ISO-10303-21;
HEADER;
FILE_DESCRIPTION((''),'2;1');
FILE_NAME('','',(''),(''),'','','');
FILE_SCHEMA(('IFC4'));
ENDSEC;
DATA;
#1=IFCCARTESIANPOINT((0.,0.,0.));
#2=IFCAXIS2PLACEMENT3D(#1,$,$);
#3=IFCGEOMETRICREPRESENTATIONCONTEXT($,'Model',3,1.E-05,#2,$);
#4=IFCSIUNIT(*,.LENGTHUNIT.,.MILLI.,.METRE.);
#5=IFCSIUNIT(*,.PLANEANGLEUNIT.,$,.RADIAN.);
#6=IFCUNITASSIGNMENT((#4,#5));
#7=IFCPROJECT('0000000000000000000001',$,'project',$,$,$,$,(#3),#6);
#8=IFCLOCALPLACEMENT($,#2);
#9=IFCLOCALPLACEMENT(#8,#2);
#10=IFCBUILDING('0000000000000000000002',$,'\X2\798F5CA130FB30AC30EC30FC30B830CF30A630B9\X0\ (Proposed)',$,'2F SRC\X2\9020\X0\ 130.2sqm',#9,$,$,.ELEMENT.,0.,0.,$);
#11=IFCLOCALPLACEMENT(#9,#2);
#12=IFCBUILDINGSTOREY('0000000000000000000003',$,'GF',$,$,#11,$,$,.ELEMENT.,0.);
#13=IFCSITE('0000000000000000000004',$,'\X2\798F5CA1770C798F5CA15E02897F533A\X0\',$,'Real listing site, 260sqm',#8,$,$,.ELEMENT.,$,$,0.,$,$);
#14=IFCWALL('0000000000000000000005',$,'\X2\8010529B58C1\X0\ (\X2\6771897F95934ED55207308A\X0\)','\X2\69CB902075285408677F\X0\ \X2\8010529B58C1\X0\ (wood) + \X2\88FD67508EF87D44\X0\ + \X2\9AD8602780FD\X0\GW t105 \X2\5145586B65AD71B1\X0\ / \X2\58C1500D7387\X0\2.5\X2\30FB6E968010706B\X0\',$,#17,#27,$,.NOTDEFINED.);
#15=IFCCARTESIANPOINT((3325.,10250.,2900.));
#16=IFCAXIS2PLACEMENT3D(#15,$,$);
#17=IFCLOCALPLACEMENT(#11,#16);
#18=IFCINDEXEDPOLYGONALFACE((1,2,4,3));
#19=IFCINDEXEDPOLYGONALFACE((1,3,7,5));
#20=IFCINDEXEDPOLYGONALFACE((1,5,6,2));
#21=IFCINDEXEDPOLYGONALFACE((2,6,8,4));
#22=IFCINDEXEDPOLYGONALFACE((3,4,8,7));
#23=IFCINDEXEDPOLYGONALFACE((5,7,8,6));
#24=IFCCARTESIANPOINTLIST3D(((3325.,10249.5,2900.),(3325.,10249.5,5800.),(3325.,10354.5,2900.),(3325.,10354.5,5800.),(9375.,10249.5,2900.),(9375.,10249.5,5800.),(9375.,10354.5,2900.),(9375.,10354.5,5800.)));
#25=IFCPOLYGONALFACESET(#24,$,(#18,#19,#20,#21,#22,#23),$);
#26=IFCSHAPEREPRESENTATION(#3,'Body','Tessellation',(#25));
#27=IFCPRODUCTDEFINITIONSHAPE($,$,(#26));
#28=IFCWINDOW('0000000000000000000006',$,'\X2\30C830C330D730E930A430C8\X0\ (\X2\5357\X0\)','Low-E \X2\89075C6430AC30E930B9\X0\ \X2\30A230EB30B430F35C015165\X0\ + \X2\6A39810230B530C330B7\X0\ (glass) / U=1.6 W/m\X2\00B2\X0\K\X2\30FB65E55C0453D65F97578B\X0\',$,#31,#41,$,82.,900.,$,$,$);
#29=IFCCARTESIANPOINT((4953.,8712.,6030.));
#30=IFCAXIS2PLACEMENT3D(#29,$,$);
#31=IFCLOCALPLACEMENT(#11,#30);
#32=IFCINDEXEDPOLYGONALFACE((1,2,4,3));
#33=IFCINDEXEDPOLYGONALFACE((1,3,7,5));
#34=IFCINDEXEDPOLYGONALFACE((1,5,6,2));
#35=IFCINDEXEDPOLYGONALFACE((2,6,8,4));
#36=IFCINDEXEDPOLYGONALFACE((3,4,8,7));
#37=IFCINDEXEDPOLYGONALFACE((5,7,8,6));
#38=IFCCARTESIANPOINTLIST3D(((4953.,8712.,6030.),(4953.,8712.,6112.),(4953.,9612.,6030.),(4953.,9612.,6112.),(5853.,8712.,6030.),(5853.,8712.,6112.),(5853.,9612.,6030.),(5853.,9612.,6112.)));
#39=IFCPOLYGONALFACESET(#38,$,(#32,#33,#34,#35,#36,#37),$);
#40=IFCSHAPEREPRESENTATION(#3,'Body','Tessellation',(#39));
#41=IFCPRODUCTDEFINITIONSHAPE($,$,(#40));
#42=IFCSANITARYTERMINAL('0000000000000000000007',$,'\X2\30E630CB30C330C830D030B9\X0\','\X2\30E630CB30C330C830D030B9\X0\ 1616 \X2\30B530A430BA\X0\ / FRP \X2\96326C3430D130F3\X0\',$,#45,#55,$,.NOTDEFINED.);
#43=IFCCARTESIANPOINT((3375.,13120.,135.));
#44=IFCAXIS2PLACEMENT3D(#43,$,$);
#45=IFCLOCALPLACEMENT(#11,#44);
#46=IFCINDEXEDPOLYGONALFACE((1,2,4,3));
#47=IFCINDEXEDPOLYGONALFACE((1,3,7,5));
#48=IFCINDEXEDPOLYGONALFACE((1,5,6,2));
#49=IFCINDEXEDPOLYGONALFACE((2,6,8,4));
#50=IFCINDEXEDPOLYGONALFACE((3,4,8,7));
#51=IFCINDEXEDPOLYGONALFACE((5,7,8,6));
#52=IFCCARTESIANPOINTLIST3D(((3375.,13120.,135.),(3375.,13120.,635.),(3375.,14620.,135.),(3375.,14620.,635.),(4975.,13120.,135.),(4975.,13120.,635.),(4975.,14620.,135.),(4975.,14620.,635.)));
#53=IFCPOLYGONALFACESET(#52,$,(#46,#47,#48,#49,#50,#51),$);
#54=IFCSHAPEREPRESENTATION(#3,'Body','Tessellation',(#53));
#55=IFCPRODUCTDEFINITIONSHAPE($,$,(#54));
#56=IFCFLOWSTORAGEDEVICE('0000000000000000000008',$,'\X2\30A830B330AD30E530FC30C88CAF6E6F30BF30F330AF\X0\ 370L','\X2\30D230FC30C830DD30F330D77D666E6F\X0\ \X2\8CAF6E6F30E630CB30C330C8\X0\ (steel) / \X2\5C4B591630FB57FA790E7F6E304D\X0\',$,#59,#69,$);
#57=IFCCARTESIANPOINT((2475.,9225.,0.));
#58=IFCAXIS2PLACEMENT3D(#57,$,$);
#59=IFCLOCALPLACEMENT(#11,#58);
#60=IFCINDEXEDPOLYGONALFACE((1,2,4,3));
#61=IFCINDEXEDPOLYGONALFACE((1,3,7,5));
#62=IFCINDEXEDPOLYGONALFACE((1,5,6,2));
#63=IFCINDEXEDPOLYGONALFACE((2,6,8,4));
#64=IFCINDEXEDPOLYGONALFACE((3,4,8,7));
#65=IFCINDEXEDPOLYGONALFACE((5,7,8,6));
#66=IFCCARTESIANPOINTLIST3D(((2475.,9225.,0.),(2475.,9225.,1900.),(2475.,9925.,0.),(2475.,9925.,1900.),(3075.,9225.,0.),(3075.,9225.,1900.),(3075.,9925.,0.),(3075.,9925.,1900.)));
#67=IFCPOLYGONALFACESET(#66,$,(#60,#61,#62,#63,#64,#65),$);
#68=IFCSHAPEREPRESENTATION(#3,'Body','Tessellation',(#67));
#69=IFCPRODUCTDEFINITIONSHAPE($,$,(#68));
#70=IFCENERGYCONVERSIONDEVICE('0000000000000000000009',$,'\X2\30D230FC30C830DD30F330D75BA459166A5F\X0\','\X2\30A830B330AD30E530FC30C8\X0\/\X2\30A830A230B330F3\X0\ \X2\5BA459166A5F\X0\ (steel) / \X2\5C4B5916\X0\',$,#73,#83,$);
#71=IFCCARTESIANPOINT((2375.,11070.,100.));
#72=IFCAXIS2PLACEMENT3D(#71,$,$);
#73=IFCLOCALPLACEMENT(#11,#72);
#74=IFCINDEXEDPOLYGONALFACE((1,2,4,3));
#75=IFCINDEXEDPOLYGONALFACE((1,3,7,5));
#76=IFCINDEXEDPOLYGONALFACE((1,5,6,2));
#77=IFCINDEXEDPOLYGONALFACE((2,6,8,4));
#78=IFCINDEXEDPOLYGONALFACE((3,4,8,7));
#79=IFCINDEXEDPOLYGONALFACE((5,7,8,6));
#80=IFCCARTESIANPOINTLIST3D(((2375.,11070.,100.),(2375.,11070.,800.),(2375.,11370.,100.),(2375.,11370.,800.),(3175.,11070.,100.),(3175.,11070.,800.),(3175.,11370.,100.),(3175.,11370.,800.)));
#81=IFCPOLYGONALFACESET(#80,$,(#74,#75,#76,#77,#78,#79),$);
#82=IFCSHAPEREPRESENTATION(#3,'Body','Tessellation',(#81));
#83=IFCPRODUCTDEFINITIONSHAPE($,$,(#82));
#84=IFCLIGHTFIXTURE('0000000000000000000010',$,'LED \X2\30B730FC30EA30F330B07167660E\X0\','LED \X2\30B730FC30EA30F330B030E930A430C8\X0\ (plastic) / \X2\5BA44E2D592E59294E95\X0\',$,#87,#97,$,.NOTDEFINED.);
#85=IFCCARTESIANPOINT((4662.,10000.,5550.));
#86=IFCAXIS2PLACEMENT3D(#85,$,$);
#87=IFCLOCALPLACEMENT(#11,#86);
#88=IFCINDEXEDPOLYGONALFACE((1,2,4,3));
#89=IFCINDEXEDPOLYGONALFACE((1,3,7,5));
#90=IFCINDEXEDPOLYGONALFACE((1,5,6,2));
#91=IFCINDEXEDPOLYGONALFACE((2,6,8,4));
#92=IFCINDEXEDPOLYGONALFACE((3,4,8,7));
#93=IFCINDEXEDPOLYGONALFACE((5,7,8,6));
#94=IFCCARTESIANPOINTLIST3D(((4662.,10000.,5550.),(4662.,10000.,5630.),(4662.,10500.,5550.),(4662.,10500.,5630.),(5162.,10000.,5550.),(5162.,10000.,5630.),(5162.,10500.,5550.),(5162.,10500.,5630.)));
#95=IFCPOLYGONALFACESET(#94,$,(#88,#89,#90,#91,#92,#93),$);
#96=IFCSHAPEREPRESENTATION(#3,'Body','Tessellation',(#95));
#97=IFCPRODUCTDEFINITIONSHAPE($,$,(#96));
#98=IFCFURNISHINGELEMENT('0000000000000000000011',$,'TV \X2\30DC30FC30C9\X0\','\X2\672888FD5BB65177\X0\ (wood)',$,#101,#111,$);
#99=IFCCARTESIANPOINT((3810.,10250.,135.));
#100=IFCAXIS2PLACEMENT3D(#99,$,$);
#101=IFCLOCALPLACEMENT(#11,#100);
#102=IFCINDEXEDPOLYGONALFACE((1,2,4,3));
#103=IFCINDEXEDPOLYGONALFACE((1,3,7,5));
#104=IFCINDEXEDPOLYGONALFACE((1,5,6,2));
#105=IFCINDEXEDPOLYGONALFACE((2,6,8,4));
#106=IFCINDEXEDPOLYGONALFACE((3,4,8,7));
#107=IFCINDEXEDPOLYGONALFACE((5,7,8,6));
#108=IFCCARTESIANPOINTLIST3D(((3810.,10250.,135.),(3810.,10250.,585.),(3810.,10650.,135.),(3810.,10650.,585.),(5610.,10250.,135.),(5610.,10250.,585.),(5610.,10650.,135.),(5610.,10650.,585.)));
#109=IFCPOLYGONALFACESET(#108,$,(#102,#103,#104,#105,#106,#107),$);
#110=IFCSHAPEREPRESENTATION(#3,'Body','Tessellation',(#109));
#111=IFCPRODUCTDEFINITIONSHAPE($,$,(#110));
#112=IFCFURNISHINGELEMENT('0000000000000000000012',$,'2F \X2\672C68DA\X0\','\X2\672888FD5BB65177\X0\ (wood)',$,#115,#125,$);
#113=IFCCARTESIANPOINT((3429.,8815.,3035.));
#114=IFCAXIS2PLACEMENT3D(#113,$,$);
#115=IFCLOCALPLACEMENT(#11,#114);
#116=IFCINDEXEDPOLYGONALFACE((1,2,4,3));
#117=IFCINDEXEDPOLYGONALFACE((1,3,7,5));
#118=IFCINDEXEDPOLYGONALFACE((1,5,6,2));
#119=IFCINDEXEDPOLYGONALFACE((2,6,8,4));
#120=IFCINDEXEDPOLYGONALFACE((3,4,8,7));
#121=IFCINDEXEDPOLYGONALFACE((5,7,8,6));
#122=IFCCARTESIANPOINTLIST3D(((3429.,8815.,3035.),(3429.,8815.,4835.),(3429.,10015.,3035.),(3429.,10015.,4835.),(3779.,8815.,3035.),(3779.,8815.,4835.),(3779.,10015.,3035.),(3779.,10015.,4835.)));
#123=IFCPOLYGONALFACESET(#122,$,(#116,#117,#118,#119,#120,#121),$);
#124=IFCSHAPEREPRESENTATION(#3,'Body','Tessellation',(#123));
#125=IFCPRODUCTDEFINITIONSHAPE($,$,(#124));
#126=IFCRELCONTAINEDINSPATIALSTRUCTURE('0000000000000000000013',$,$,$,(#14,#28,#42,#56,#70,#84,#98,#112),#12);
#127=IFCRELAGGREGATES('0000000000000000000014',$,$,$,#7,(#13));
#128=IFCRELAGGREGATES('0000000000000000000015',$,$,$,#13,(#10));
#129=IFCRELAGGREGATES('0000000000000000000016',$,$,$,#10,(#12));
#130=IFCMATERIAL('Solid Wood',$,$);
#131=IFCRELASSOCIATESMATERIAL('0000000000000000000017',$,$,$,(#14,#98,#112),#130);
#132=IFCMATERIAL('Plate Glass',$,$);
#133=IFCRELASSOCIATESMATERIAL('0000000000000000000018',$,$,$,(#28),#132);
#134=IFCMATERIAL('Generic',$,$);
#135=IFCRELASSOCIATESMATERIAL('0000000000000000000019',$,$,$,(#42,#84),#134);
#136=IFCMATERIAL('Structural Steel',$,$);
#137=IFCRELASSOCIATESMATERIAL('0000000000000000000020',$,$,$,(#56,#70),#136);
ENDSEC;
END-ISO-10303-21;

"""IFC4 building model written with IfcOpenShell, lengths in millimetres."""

from ifc_helpers import new_model, si_unit, frame, frame_2d, origin, place, context, project, spatial, rectangle, extrude, material, element, save


model = new_model("IFC4")

# Units and contexts
model_context = context("Model", 3, precision=1e-05, world=origin())
ifc_project = project(units=[si_unit("LENGTHUNIT", "METRE", prefix="MILLI"), si_unit("PLANEANGLEUNIT", "RADIAN")], contexts=[model_context])

# Site, building, storey
site_placement = place(None, origin())
site = spatial("IfcSite", under=ifc_project, at=site_placement, Name="福岡県福岡市西区", ObjectType="Real listing site, 260sqm", CompositionType="ELEMENT", RefElevation=0.0)
building_placement = place(site_placement, origin())
building = spatial("IfcBuilding", under=site, at=building_placement, Name="福岡・ガレージハウス (Proposed)", ObjectType="2F SRC造 130.2sqm", CompositionType="ELEMENT", ElevationOfRefHeight=0.0, ElevationOfTerrain=0.0)
storey_placement = place(building_placement, origin())
storey = spatial("IfcBuildingStorey", under=building, at=storey_placement, Name="GF", CompositionType="ELEMENT", Elevation=0.0)

# Shared definitions
ifc_material_1 = material(Name="Solid Wood")

# Wall
wall_1_placement = place(storey_placement, frame((3325.0, 10250.0, 2900.0)))
element("IfcWall", 1, at=wall_1_placement, inside=storey, material=ifc_material_1, Name="耐力壁 (東西間仕切り)", Description="構造用合板 耐力壁 (wood) + 製材軸組 + 高性能GW t105 充填断熱 / 壁倍率2.5・準耐火", PredefinedType="NOTDEFINED", context=model_context, shape_type="SweptSolid", body=[
    extrude(rectangle(XDim=6050.0, YDim=105.0, at=frame_2d((3025.0, 52.0))), frame((3325.0, 10250.0, 2900.0)), (0.0, 0.0, 1.0), 2900.0),
])

# Window
ifc_material_2 = material(Name="Plate Glass")
window_placement = place(storey_placement, frame((4953.0, 8712.0, 6030.0)))
element("IfcWindow", 2, at=window_placement, inside=storey, material=ifc_material_2, Name="トップライト (南)", Description="Low-E 複層ガラス アルゴン封入 + 樹脂サッシ (glass) / U=1.6 W/m²K・日射取得型", OverallHeight=82.0, OverallWidth=900.0, context=model_context, shape_type="SweptSolid", body=[
    extrude(rectangle(XDim=900.0, YDim=900.0, at=frame_2d((450.0, 450.0))), frame((4953.0, 8712.0, 6030.0)), (0.0, 0.0, 1.0), 82.0),
])

# Sanitary terminal
ifc_material_3 = material(Name="Generic")
sanitary_terminal_placement = place(storey_placement, frame((3375.0, 13120.0, 135.0)))
element("IfcSanitaryTerminal", 3, at=sanitary_terminal_placement, inside=storey, material=ifc_material_3, Name="ユニットバス", Description="ユニットバス 1616 サイズ / FRP 防水パン", PredefinedType="NOTDEFINED", context=model_context, shape_type="SweptSolid", body=[
    extrude(rectangle(XDim=1600.0, YDim=1500.0, at=frame_2d((800.0, 750.0))), frame((3375.0, 13120.0, 135.0)), (0.0, 0.0, 1.0), 500.0),
])

# Flow storage device
ifc_material_4 = material(Name="Structural Steel")
flow_storage_device_placement = place(storey_placement, frame((2475.0, 9225.0, 0.0)))
element("IfcFlowStorageDevice", 4, at=flow_storage_device_placement, inside=storey, material=ifc_material_4, Name="エコキュート貯湯タンク 370L", Description="ヒートポンプ給湯 貯湯ユニット (steel) / 屋外・基礎置き", context=model_context, shape_type="SweptSolid", body=[
    extrude(rectangle(XDim=600.0, YDim=700.0, at=frame_2d((300.0, 350.0))), frame((2475.0, 9225.0, 0.0)), (0.0, 0.0, 1.0), 1900.0),
])

# Energy conversion device
energy_conversion_device_placement = place(storey_placement, frame((2375.0, 11070.0, 100.0)))
element("IfcEnergyConversionDevice", 5, at=energy_conversion_device_placement, inside=storey, material=ifc_material_4, Name="ヒートポンプ室外機", Description="エコキュート/エアコン 室外機 (steel) / 屋外", context=model_context, shape_type="SweptSolid", body=[
    extrude(rectangle(XDim=800.0, YDim=300.0, at=frame_2d((400.0, 150.0))), frame((2375.0, 11070.0, 100.0)), (0.0, 0.0, 1.0), 700.0),
])

# Light fixture
light_fixture_placement = place(storey_placement, frame((4662.0, 10000.0, 5550.0)))
element("IfcLightFixture", 6, at=light_fixture_placement, inside=storey, material=ifc_material_3, Name="LED シーリング照明", Description="LED シーリングライト (plastic) / 室中央天井", PredefinedType="NOTDEFINED", context=model_context, shape_type="SweptSolid", body=[
    extrude(rectangle(XDim=500.0, YDim=500.0, at=frame_2d((250.0, 250.0))), frame((4662.0, 10000.0, 5550.0)), (0.0, 0.0, 1.0), 80.0),
])

# Furnishing elements
furnishing_1_placement = place(storey_placement, frame((3810.0, 10250.0, 135.0)))
element("IfcFurnishingElement", 7, at=furnishing_1_placement, inside=storey, material=ifc_material_1, Name="TV ボード", Description="木製家具 (wood)", context=model_context, shape_type="SweptSolid", body=[
    extrude(rectangle(XDim=1800.0, YDim=400.0, at=frame_2d((900.0, 200.0))), frame((3810.0, 10250.0, 135.0)), (0.0, 0.0, 1.0), 450.0),
])
furnishing_2_placement = place(storey_placement, frame((3429.0, 8815.0, 3035.0)))
element("IfcFurnishingElement", 8, at=furnishing_2_placement, inside=storey, material=ifc_material_1, Name="2F 本棚", Description="木製家具 (wood)", context=model_context, shape_type="SweptSolid", body=[
    extrude(rectangle(XDim=350.0, YDim=1200.0, at=frame_2d((175.0, 600.0))), frame((3429.0, 8815.0, 3035.0)), (0.0, 0.0, 1.0), 1800.0),
])

save(model, "model.ifc")
